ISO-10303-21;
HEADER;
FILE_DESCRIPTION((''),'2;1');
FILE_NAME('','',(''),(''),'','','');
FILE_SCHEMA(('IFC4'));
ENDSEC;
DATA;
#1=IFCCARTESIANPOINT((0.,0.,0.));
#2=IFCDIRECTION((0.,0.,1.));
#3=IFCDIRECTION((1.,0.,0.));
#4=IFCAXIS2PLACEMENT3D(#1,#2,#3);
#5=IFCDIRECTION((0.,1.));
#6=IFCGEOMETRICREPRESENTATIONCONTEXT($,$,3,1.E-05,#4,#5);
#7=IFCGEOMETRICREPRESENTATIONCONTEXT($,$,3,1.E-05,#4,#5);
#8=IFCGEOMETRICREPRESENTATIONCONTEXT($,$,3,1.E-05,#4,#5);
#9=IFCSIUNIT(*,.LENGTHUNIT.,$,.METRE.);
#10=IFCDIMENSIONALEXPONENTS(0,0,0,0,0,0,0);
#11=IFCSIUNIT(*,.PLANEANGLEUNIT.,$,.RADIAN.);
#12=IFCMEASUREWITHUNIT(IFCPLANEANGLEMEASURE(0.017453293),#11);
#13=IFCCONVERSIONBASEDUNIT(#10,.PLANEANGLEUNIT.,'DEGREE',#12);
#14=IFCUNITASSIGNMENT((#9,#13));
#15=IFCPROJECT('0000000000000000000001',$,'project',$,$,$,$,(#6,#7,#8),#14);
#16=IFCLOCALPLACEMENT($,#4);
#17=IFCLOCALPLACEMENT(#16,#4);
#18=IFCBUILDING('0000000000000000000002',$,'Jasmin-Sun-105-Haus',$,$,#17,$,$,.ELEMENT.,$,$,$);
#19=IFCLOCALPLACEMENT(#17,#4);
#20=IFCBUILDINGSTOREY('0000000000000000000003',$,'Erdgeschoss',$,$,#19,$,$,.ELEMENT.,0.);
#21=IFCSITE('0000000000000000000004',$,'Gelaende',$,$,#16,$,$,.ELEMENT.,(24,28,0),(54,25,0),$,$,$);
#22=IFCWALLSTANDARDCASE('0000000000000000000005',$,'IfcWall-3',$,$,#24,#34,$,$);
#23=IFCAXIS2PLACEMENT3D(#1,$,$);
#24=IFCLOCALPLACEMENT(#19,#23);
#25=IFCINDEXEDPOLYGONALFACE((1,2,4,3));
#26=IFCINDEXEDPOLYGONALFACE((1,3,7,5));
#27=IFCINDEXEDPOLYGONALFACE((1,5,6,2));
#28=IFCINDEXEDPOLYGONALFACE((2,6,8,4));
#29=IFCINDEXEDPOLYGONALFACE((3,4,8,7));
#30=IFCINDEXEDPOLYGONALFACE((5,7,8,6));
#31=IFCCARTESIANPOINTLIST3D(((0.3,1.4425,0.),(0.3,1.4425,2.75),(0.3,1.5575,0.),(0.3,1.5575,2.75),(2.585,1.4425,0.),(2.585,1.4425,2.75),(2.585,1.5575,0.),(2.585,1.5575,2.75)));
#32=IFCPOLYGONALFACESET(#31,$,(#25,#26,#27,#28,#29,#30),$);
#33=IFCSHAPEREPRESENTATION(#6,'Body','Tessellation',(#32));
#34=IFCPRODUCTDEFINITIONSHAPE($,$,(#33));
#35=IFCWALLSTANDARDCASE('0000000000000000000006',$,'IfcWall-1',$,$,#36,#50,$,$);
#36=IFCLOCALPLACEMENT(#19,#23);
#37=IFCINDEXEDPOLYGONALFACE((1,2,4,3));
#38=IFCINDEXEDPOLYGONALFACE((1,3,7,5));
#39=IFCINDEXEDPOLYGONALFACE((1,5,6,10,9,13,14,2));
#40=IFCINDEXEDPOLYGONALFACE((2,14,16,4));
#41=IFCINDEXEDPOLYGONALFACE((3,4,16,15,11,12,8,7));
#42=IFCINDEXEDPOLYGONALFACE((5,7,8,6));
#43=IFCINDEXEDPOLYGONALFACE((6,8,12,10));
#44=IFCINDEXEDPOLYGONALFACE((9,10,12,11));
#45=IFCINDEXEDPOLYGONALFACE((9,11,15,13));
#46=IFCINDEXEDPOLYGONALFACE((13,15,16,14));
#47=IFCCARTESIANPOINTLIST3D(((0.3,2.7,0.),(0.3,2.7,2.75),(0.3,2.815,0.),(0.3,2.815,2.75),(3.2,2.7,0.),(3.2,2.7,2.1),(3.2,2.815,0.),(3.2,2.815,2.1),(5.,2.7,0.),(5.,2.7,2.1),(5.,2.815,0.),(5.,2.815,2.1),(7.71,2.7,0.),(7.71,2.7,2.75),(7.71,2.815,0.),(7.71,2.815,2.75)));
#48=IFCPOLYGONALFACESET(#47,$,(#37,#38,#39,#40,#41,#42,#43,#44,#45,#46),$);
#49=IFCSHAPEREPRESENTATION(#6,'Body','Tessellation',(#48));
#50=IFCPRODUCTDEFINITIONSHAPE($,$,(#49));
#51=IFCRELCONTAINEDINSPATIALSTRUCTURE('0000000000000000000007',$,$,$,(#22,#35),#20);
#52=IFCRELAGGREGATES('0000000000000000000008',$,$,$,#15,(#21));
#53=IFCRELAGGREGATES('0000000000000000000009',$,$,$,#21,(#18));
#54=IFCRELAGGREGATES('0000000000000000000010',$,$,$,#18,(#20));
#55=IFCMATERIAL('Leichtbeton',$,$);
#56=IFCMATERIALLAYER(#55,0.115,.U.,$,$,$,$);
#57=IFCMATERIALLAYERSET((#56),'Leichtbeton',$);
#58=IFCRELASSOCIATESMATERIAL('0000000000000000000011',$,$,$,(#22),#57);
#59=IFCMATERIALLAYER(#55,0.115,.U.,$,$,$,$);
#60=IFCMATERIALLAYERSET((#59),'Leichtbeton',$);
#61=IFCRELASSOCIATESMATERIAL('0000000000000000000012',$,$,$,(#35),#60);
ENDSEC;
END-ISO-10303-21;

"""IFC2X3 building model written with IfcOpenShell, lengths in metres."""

from ifc_helpers import new_model, entity, si_unit, converted_unit, direction, frame, frame_2d, origin_with_axes, place, context, project, spatial, polyline, rectangle, outline, extrude, material, layer, layer_set, layer_usage, element, save


model = new_model("IFC2X3")

# Units and contexts
context_of_model_1 = context(None, 3, precision=1e-05, world=origin_with_axes(), true_north=direction((0.0, 1.0)))
context_of_model_2 = context(None, 3, precision=1e-05, world=origin_with_axes(), true_north=direction((0.0, 1.0)))
context_of_model_3 = context(None, 3, precision=1e-05, world=origin_with_axes(), true_north=direction((0.0, 1.0)))
ifc_project = project(units=[si_unit("LENGTHUNIT", "METRE"), converted_unit("PLANEANGLEUNIT", "DEGREE", entity("IfcPlaneAngleMeasure", 0.017453293), si_unit("PLANEANGLEUNIT", "RADIAN"), dimensions=[0, 0, 0, 0, 0, 0, 0])], contexts=[context_of_model_1, context_of_model_2, context_of_model_3])

# Site, building, storey
site_placement = place(None, origin_with_axes())
site = spatial("IfcSite", under=ifc_project, at=site_placement, Name="Gelaende", CompositionType="ELEMENT", RefLatitude=(24, 28, 0), RefLongitude=(54, 25, 0))
building_placement = place(site_placement, origin_with_axes())
building = spatial("IfcBuilding", under=site, at=building_placement, Name="Jasmin-Sun-105-Haus", CompositionType="ELEMENT")
storey_placement = place(building_placement, origin_with_axes())
storey = spatial("IfcBuildingStorey", under=building, at=storey_placement, Name="Erdgeschoss", CompositionType="ELEMENT", Elevation=0.0)

# Shared definitions
ifc_material_1 = material(Name="Leichtbeton")

# Wall
ifc_layer_1 = layer(ifc_material_1, 0.115, ventilated="UNKNOWN")
ifc_layer_set_1 = layer_set([ifc_layer_1], Name="Leichtbeton")
ifc_layer_usage_1 = layer_usage(ifc_layer_set_1, "AXIS2", "POSITIVE", 0.0)
wall_1_placement = place(storey_placement, frame((0.0, 1.4425, 0.0), z_axis=(0.0, 0.0, 1.0), x_axis=(1.0, 0.0, 0.0)))
element("IfcWallStandardCase", 1, at=wall_1_placement, inside=storey, material=ifc_layer_usage_1, Name="IfcWall-3", context=context_of_model_1, shape_type="SweptSolid", body=[
    extrude(outline(polyline([(0.3, 0.0), (2.585, 0.0), (2.585, 0.115), (0.3, 0.115), (0.3, 0.0)])), origin_with_axes(), (0.0, 0.0, 1.0), 2.75),
])

# Wall, opening
ifc_layer_2 = layer(ifc_material_1, 0.115, ventilated="UNKNOWN")
ifc_layer_set_2 = layer_set([ifc_layer_2], Name="Leichtbeton")
ifc_layer_usage_2 = layer_usage(ifc_layer_set_2, "AXIS2", "POSITIVE", 0.0)
wall_2_placement = place(storey_placement, frame((0.0, 2.7, 0.0), z_axis=(0.0, 0.0, 1.0), x_axis=(1.0, 0.0, 0.0)))
wall_2 = element("IfcWallStandardCase", 2, at=wall_2_placement, inside=storey, material=ifc_layer_usage_2, Name="IfcWall-1", context=context_of_model_1, shape_type="SweptSolid", body=[
    extrude(outline(polyline([(0.3, 0.0), (7.71, 0.0), (7.71, 0.115), (0.3, 0.115), (0.3, 0.0)])), origin_with_axes(), (0.0, 0.0, 1.0), 2.75),
])
opening_1_placement = place(wall_2_placement, frame((4.1, 0.0, 0.0), z_axis=(0.0, 0.0, 1.0), x_axis=(1.0, 0.0, 0.0)))
element("IfcOpeningElement", 3, at=opening_1_placement, inside=storey, cuts=wall_2, context=context_of_model_1, shape_type="SweptSolid", body=[
    extrude(rectangle(XDim=2.1, YDim=1.8, at=frame_2d((0.0, 1.05), x_axis=(0.0, -1.0))), frame((0.0, 0.0, 0.0), z_axis=(0.0, 1.0, 0.0), x_axis=(-1.0, 0.0, 0.0)), (0.0, 0.0, 1.0), 0.115),
])

save(model, "model.ifc")
